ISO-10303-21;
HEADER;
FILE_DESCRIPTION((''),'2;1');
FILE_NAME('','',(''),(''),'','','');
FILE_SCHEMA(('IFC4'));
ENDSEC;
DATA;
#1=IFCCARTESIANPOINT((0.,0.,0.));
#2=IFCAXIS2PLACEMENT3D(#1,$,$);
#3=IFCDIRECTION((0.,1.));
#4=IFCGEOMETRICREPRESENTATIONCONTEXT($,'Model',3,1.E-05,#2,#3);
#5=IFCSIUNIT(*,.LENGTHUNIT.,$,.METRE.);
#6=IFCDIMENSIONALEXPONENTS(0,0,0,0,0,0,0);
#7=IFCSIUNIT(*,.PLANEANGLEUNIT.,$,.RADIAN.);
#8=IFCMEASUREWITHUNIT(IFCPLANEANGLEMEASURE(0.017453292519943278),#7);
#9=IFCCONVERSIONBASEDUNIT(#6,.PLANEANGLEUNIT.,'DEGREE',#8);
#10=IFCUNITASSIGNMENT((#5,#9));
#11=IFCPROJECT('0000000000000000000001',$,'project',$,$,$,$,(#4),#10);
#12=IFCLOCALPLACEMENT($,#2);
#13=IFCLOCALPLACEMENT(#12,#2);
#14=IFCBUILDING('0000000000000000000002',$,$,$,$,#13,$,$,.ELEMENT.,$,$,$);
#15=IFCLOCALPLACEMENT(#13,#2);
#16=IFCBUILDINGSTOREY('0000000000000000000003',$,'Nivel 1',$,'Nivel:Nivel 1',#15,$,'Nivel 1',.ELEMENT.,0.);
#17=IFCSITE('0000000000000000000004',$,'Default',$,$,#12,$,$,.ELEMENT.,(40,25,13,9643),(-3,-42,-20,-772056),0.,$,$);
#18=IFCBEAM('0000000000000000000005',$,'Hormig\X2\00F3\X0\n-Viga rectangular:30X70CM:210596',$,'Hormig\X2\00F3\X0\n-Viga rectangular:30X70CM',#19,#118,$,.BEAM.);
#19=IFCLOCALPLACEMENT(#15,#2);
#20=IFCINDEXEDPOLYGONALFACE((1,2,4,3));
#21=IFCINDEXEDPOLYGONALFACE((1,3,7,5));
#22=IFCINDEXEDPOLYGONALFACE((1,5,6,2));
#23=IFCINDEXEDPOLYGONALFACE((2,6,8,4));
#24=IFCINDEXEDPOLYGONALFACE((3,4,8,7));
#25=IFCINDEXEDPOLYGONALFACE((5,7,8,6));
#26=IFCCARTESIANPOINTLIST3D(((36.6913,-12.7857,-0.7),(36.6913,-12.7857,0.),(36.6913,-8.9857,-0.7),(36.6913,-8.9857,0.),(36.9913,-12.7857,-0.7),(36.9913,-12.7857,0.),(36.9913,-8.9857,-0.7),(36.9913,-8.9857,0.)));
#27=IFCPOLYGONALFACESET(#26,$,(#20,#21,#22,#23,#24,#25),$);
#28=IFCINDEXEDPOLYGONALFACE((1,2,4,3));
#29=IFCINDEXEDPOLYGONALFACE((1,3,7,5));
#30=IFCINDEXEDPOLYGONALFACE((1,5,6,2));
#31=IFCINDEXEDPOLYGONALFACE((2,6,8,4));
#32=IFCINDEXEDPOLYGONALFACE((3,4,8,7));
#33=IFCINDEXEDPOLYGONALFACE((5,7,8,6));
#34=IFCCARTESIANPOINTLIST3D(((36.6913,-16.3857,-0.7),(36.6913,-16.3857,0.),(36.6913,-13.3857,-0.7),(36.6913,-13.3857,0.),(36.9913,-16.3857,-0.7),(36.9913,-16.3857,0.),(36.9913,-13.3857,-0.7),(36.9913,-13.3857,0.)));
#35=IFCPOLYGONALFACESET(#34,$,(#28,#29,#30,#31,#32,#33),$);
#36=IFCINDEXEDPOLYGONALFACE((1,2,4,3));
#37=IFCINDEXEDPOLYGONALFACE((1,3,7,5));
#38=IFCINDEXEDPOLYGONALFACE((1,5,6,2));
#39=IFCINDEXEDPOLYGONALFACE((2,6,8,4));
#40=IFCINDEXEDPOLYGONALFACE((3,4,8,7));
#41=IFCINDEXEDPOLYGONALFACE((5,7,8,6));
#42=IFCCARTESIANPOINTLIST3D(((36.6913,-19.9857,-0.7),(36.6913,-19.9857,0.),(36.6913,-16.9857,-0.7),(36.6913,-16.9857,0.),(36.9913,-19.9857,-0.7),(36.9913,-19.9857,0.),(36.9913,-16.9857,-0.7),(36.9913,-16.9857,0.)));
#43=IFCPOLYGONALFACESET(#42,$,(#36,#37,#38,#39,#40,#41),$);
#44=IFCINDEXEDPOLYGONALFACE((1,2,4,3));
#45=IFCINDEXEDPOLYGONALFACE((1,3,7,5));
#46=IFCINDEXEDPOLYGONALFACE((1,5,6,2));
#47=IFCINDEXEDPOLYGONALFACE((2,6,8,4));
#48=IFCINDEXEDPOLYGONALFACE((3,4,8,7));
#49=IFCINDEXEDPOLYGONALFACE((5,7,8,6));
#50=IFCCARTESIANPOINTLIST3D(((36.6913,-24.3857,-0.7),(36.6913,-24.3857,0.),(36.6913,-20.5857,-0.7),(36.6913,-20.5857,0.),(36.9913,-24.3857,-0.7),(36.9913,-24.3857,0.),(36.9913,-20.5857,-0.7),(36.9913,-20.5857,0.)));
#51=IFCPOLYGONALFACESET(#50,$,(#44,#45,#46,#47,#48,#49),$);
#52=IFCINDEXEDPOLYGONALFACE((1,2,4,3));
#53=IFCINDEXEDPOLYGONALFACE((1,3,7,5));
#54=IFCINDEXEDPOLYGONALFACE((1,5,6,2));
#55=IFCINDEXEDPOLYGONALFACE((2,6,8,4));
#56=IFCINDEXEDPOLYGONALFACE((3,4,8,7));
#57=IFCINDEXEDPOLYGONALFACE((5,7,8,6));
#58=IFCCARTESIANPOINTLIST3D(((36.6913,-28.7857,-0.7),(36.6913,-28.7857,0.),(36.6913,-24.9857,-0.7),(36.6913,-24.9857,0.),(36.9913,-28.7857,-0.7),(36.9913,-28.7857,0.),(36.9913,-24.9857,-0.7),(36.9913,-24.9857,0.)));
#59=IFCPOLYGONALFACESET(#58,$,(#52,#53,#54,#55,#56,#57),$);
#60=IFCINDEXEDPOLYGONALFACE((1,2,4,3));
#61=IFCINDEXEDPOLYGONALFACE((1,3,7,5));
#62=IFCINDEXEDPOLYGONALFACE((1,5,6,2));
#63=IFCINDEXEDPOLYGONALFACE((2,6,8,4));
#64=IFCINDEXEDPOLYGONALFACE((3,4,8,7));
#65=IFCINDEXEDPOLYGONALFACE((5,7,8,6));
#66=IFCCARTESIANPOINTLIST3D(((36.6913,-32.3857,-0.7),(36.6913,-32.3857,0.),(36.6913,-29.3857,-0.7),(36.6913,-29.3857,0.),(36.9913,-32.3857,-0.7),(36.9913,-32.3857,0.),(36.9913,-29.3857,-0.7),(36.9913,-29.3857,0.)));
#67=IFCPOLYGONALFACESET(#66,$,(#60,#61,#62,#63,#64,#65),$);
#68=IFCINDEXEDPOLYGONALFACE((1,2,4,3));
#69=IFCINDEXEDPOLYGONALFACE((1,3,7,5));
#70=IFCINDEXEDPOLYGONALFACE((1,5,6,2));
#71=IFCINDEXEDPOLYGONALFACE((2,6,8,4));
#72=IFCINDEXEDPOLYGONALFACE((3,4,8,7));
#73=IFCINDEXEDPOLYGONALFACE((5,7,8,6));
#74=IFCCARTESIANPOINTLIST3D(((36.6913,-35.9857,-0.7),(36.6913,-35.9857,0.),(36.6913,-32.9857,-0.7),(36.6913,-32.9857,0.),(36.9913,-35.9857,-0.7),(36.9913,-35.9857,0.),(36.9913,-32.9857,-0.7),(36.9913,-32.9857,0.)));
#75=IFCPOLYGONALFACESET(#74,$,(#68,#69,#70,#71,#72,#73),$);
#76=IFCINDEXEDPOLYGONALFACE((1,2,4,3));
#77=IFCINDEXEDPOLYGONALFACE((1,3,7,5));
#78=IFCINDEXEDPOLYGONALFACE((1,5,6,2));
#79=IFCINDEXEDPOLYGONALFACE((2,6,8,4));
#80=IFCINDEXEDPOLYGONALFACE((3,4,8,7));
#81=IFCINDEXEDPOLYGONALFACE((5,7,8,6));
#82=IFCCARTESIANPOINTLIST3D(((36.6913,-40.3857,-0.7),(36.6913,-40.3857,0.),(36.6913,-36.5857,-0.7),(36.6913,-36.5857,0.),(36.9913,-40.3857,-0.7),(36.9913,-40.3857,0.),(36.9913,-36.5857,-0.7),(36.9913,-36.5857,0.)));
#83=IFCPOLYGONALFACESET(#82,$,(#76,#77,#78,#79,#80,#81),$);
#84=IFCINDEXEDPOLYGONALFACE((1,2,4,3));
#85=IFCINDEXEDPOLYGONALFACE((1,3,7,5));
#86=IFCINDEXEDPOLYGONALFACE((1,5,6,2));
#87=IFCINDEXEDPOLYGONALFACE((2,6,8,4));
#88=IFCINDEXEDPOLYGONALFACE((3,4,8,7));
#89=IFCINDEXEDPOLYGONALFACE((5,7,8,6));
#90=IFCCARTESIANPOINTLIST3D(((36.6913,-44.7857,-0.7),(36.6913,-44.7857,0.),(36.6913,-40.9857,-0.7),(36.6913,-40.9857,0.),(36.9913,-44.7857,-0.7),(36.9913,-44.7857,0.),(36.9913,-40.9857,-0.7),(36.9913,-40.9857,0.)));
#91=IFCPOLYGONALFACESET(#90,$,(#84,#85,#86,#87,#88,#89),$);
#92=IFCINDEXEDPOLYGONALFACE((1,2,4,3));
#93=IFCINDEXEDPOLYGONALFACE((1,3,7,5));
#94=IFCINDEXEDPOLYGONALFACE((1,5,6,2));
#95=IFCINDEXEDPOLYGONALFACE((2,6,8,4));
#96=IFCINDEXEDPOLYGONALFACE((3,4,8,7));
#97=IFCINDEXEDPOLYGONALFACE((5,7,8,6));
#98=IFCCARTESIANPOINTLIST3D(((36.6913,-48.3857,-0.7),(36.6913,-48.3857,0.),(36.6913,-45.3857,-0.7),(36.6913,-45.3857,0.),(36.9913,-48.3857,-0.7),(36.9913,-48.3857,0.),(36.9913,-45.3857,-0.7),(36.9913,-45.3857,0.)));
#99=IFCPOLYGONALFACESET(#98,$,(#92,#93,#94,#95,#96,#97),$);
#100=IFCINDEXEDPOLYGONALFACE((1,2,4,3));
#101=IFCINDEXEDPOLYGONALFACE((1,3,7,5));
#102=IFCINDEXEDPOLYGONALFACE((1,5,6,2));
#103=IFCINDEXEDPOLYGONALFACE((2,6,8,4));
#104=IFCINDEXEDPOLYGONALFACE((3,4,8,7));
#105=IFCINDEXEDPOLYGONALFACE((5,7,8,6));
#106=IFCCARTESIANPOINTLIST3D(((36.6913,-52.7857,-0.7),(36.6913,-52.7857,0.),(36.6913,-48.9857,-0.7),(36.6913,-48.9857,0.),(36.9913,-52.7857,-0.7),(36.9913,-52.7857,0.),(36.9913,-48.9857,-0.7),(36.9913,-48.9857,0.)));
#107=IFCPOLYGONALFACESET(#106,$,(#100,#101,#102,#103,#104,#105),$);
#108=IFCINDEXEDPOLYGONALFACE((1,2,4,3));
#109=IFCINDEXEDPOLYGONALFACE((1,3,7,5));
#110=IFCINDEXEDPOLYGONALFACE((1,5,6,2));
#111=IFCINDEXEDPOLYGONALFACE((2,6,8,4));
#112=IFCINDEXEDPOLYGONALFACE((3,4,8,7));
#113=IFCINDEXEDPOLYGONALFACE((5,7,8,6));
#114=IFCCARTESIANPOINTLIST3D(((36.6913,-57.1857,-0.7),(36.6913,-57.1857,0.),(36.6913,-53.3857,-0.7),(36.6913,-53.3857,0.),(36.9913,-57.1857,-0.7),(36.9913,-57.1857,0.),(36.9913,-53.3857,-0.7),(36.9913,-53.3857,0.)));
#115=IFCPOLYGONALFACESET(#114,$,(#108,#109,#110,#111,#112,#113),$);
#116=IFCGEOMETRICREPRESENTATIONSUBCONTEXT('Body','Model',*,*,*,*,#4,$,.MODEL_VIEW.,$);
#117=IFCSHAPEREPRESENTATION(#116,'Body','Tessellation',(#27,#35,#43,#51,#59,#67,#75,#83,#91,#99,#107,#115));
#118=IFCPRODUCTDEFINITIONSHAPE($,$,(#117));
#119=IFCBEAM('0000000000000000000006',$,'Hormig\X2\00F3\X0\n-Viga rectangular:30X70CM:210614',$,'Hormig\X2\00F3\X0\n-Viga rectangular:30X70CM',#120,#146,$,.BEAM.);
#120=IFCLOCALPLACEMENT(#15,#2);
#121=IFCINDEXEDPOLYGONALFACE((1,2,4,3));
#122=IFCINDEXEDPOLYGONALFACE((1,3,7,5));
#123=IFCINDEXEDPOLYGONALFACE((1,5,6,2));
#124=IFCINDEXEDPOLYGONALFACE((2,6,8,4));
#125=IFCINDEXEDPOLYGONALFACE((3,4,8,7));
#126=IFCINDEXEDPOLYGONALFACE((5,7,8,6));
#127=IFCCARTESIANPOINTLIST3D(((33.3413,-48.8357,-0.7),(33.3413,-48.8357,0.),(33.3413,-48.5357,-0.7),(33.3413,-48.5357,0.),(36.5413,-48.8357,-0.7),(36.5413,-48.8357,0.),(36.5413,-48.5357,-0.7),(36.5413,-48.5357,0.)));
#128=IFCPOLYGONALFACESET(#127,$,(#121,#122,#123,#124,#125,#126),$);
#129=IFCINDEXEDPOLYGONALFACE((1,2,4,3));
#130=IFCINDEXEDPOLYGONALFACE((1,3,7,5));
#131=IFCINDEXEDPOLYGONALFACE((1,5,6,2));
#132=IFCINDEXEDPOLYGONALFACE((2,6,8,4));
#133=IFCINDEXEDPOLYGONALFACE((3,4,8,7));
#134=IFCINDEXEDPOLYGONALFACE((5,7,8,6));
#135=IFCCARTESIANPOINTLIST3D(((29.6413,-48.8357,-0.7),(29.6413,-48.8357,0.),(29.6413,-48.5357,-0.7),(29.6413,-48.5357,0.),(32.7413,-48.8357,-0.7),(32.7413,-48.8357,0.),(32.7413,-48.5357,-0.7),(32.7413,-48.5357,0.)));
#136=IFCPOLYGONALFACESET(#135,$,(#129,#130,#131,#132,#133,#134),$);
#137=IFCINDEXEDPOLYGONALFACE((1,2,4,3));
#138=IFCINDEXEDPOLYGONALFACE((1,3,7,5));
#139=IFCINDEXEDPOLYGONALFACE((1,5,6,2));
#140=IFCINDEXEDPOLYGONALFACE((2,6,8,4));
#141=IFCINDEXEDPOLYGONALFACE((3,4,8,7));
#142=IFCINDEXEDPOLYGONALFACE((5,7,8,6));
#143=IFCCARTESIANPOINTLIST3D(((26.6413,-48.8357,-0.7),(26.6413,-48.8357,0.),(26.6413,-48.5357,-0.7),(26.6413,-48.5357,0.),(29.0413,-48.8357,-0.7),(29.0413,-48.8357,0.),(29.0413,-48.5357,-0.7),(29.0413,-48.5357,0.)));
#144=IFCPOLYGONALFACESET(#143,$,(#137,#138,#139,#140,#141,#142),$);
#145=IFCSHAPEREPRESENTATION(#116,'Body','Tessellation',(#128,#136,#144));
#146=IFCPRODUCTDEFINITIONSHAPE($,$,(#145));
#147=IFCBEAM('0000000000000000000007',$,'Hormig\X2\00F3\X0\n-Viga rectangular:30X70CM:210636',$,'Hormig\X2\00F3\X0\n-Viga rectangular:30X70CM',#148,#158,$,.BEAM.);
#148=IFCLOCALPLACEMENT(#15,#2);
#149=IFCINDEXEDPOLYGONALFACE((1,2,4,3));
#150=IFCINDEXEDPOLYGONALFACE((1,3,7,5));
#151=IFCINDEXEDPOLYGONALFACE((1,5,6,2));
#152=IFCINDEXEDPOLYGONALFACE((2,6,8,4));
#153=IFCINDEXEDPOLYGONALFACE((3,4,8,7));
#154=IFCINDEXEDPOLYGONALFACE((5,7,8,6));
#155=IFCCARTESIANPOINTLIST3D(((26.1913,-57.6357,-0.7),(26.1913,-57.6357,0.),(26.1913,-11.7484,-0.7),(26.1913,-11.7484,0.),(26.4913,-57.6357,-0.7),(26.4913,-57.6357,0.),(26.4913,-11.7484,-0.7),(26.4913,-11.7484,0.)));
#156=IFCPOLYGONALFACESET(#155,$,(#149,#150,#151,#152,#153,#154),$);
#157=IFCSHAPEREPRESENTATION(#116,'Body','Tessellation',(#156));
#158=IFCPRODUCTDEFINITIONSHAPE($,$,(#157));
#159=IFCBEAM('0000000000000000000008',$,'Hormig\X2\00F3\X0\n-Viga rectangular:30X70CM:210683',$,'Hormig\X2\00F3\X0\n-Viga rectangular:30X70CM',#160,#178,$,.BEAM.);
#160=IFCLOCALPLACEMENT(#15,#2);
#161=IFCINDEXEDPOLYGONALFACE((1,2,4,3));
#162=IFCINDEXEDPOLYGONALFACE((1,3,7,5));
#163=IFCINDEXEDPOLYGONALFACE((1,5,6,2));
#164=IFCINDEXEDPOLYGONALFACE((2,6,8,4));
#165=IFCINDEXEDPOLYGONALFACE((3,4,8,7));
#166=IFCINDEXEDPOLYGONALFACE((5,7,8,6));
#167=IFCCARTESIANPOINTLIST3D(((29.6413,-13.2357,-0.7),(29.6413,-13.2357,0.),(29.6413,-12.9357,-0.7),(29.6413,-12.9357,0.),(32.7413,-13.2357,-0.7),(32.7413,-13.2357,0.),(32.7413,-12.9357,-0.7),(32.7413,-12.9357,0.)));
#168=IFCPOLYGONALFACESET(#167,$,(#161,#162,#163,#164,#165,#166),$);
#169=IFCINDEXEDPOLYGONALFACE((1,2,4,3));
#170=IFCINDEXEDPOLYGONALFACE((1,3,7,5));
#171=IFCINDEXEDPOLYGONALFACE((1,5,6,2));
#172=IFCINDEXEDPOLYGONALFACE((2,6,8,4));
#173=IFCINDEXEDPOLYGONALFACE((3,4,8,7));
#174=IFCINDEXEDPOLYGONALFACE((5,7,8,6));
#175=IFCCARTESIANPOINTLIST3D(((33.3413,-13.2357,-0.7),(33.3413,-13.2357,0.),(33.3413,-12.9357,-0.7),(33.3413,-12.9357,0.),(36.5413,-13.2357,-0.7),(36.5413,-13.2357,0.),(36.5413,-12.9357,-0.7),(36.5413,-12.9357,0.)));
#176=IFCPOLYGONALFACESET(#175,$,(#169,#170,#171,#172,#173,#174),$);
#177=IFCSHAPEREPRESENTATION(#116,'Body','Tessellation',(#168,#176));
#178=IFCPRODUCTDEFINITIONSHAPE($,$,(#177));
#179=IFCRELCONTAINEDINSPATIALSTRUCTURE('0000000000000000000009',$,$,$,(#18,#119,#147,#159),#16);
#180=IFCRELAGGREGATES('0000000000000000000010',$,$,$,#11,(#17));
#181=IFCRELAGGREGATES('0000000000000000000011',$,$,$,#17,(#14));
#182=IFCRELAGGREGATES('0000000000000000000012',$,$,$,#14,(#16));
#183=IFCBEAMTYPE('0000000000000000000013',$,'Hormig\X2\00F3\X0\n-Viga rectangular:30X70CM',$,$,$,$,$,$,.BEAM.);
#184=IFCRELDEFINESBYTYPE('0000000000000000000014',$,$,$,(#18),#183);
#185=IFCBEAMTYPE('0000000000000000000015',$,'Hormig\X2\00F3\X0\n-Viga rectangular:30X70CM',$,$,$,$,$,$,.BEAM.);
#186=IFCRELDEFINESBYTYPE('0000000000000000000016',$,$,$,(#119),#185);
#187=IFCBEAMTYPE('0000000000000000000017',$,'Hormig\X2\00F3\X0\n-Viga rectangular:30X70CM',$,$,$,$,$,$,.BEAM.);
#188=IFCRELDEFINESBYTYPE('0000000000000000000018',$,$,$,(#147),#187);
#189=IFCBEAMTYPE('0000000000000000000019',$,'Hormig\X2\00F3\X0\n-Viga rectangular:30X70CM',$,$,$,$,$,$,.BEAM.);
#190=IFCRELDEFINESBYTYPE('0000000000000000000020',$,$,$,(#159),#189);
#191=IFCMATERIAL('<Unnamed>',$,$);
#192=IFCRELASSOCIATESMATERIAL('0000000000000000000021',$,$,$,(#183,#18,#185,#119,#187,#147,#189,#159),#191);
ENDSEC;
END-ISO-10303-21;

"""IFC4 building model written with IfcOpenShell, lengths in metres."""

from ifc_helpers import new_model, entity, si_unit, converted_unit, direction, frame, origin, place, context, subcontext, project, spatial, indexed_curve, outline, extrude, source, transform, mapped, material, type_object, type_shapes, element, save


model = new_model("IFC4")

# Units and contexts
model_context = context("Model", 3, precision=1e-05, world=origin(), true_north=direction((0.0, 1.0)))
body_context = subcontext(model_context, "Body", "Model", "MODEL_VIEW")
ifc_project = project(units=[si_unit("LENGTHUNIT", "METRE"), converted_unit("PLANEANGLEUNIT", "DEGREE", entity("IfcPlaneAngleMeasure", 0.017453292519943278), si_unit("PLANEANGLEUNIT", "RADIAN"), dimensions=[0, 0, 0, 0, 0, 0, 0])], contexts=[model_context])

# Site, building, storey
site_placement = place(None, origin())
site = spatial("IfcSite", under=ifc_project, at=site_placement, Name="Default", CompositionType="ELEMENT", RefLatitude=(40, 25, 13, 9643), RefLongitude=(-3, -42, -20, -772056), RefElevation=0.0)
building_placement = place(site_placement, origin())
building = spatial("IfcBuilding", under=site, at=building_placement, CompositionType="ELEMENT")
storey_placement = place(building_placement, origin())
storey = spatial("IfcBuildingStorey", under=building, at=storey_placement, Name="Nivel 1", ObjectType="Nivel:Nivel 1", LongName="Nivel 1", CompositionType="ELEMENT", Elevation=0.0)

# Beams
ifc_material_1 = material(Name="<Unnamed>")
beam_type_1 = type_object("IfcBeamType", Name="Hormigón-Viga rectangular:30X70CM", PredefinedType="BEAM", material=ifc_material_1)
shared_shape_1 = source(origin(), body_context, "Body", "SweptSolid", [
    extrude(outline(indexed_curve([(-0.15, -0.35), (0.15, -0.35), (0.15, 0.35), (-0.15, 0.35), (-0.15, -0.35)], self_intersect=False)), frame((36.8413, -8.9857, -0.35), z_axis=(0.0, -1.0, 0.0), x_axis=(-1.0, 0.0, 0.0)), (0.0, 0.0, 1.0), 3.8),
    extrude(outline(indexed_curve([(-0.15, -0.35), (0.15, -0.35), (0.15, 0.35), (-0.15, 0.35), (-0.15, -0.35)], self_intersect=False)), frame((36.8413, -13.3857, -0.35), z_axis=(0.0, -1.0, 0.0), x_axis=(-1.0, 0.0, 0.0)), (0.0, 0.0, 1.0), 3.0),
    extrude(outline(indexed_curve([(-0.15, -0.35), (0.15, -0.35), (0.15, 0.35), (-0.15, 0.35), (-0.15, -0.35)], self_intersect=False)), frame((36.8413, -16.9857, -0.35), z_axis=(0.0, -1.0, 0.0), x_axis=(-1.0, 0.0, 0.0)), (0.0, 0.0, 1.0), 3.0),
    extrude(outline(indexed_curve([(-0.15, -0.35), (0.15, -0.35), (0.15, 0.35), (-0.15, 0.35), (-0.15, -0.35)], self_intersect=False)), frame((36.8413, -20.5857, -0.35), z_axis=(0.0, -1.0, 0.0), x_axis=(-1.0, 0.0, 0.0)), (0.0, 0.0, 1.0), 3.8),
    extrude(outline(indexed_curve([(-0.15, -0.35), (0.15, -0.35), (0.15, 0.35), (-0.15, 0.35), (-0.15, -0.35)], self_intersect=False)), frame((36.8413, -24.9857, -0.35), z_axis=(0.0, -1.0, 0.0), x_axis=(-1.0, 0.0, 0.0)), (0.0, 0.0, 1.0), 3.8),
    extrude(outline(indexed_curve([(-0.15, -0.35), (0.15, -0.35), (0.15, 0.35), (-0.15, 0.35), (-0.15, -0.35)], self_intersect=False)), frame((36.8413, -29.3857, -0.35), z_axis=(0.0, -1.0, 0.0), x_axis=(-1.0, 0.0, 0.0)), (0.0, 0.0, 1.0), 3.0),
    extrude(outline(indexed_curve([(-0.15, -0.35), (0.15, -0.35), (0.15, 0.35), (-0.15, 0.35), (-0.15, -0.35)], self_intersect=False)), frame((36.8413, -32.9857, -0.35), z_axis=(0.0, -1.0, 0.0), x_axis=(-1.0, 0.0, 0.0)), (0.0, 0.0, 1.0), 3.0),
    extrude(outline(indexed_curve([(-0.15, -0.35), (0.15, -0.35), (0.15, 0.35), (-0.15, 0.35), (-0.15, -0.35)], self_intersect=False)), frame((36.8413, -36.5857, -0.35), z_axis=(0.0, -1.0, 0.0), x_axis=(-1.0, 0.0, 0.0)), (0.0, 0.0, 1.0), 3.8),
    extrude(outline(indexed_curve([(-0.15, -0.35), (0.15, -0.35), (0.15, 0.35), (-0.15, 0.35), (-0.15, -0.35)], self_intersect=False)), frame((36.8413, -40.9857, -0.35), z_axis=(0.0, -1.0, 0.0), x_axis=(-1.0, 0.0, 0.0)), (0.0, 0.0, 1.0), 3.8),
    extrude(outline(indexed_curve([(-0.15, -0.35), (0.15, -0.35), (0.15, 0.35), (-0.15, 0.35), (-0.15, -0.35)], self_intersect=False)), frame((36.8413, -45.3857, -0.35), z_axis=(0.0, -1.0, 0.0), x_axis=(-1.0, 0.0, 0.0)), (0.0, 0.0, 1.0), 3.0),
    extrude(outline(indexed_curve([(-0.15, -0.35), (0.15, -0.35), (0.15, 0.35), (-0.15, 0.35), (-0.15, -0.35)], self_intersect=False)), frame((36.8413, -48.9857, -0.35), z_axis=(0.0, -1.0, 0.0), x_axis=(-1.0, 0.0, 0.0)), (0.0, 0.0, 1.0), 3.8),
    extrude(outline(indexed_curve([(-0.15, -0.35), (0.15, -0.35), (0.15, 0.35), (-0.15, 0.35), (-0.15, -0.35)], self_intersect=False)), frame((36.8413, -53.3857, -0.35), z_axis=(0.0, -1.0, 0.0), x_axis=(-1.0, 0.0, 0.0)), (0.0, 0.0, 1.0), 3.8),
])
type_shapes(beam_type_1, [shared_shape_1])
beam_1_placement = place(storey_placement, origin())
element("IfcBeam", 1, at=beam_1_placement, inside=storey, type_object=beam_type_1, material=ifc_material_1, Name="Hormigón-Viga rectangular:30X70CM:210596", ObjectType="Hormigón-Viga rectangular:30X70CM", PredefinedType="BEAM", context=body_context, shape_type="MappedRepresentation", body=[
    mapped(shared_shape_1, transform((0.0, 0.0, 0.0), scale=1.0)),
])
beam_type_2 = type_object("IfcBeamType", Name="Hormigón-Viga rectangular:30X70CM", PredefinedType="BEAM", material=ifc_material_1)
shared_shape_2 = source(origin(), body_context, "Body", "SweptSolid", [
    extrude(outline(indexed_curve([(-0.35, -0.15), (0.35, -0.15), (0.35, 0.15), (-0.35, 0.15), (-0.35, -0.15)], self_intersect=False)), frame((36.5413, -48.6857, -0.35), z_axis=(-1.0, 0.0, 0.0), x_axis=(0.0, 0.0, -1.0)), (0.0, 0.0, 1.0), 3.2),
    extrude(outline(indexed_curve([(-0.35, -0.15), (0.35, -0.15), (0.35, 0.15), (-0.35, 0.15), (-0.35, -0.15)], self_intersect=False)), frame((32.7413, -48.6857, -0.35), z_axis=(-1.0, 0.0, 0.0), x_axis=(0.0, 0.0, -1.0)), (0.0, 0.0, 1.0), 3.1),
    extrude(outline(indexed_curve([(-0.35, -0.15), (0.35, -0.15), (0.35, 0.15), (-0.35, 0.15), (-0.35, -0.15)], self_intersect=False)), frame((29.0413, -48.6857, -0.35), z_axis=(-1.0, 0.0, 0.0), x_axis=(0.0, 0.0, -1.0)), (0.0, 0.0, 1.0), 2.4),
])
type_shapes(beam_type_2, [shared_shape_2])
beam_2_placement = place(storey_placement, origin())
element("IfcBeam", 2, at=beam_2_placement, inside=storey, type_object=beam_type_2, material=ifc_material_1, Name="Hormigón-Viga rectangular:30X70CM:210614", ObjectType="Hormigón-Viga rectangular:30X70CM", PredefinedType="BEAM", context=body_context, shape_type="MappedRepresentation", body=[
    mapped(shared_shape_2, transform((0.0, 0.0, 0.0), scale=1.0)),
])
beam_type_3 = type_object("IfcBeamType", Name="Hormigón-Viga rectangular:30X70CM", PredefinedType="BEAM", material=ifc_material_1)
shared_shape_3 = source(origin(), body_context, "Body", "SweptSolid", [
    extrude(outline(indexed_curve([(-0.15, -0.35), (0.15, -0.35), (0.15, 0.35), (-0.15, 0.35), (-0.15, -0.35)], self_intersect=False)), frame((26.3413, -57.6357, -0.35), z_axis=(0.0, 1.0, 0.0), x_axis=(-1.0, 0.0, 0.0)), (0.0, 0.0, 1.0), 45.8873),
])
type_shapes(beam_type_3, [shared_shape_3])
beam_3_placement = place(storey_placement, origin())
element("IfcBeam", 3, at=beam_3_placement, inside=storey, type_object=beam_type_3, material=ifc_material_1, Name="Hormigón-Viga rectangular:30X70CM:210636", ObjectType="Hormigón-Viga rectangular:30X70CM", PredefinedType="BEAM", context=body_context, shape_type="MappedRepresentation", body=[
    mapped(shared_shape_3, transform((0.0, 0.0, 0.0), scale=1.0)),
])
beam_type_4 = type_object("IfcBeamType", Name="Hormigón-Viga rectangular:30X70CM", PredefinedType="BEAM", material=ifc_material_1)
shared_shape_4 = source(origin(), body_context, "Body", "SweptSolid", [
    extrude(outline(indexed_curve([(-0.35, -0.15), (0.35, -0.15), (0.35, 0.15), (-0.35, 0.15), (-0.35, -0.15)], self_intersect=False)), frame((29.6413, -13.0857, -0.35), z_axis=(1.0, 0.0, 0.0), x_axis=(0.0, 0.0, -1.0)), (0.0, 0.0, 1.0), 3.1),
    extrude(outline(indexed_curve([(-0.35, -0.15), (0.35, -0.15), (0.35, 0.15), (-0.35, 0.15), (-0.35, -0.15)], self_intersect=False)), frame((33.3413, -13.0857, -0.35), z_axis=(1.0, 0.0, 0.0), x_axis=(0.0, 0.0, -1.0)), (0.0, 0.0, 1.0), 3.2),
])
type_shapes(beam_type_4, [shared_shape_4])
beam_4_placement = place(storey_placement, origin())
element("IfcBeam", 4, at=beam_4_placement, inside=storey, type_object=beam_type_4, material=ifc_material_1, Name="Hormigón-Viga rectangular:30X70CM:210683", ObjectType="Hormigón-Viga rectangular:30X70CM", PredefinedType="BEAM", context=body_context, shape_type="MappedRepresentation", body=[
    mapped(shared_shape_4, transform((0.0, 0.0, 0.0), scale=1.0)),
])

save(model, "model.ifc")
